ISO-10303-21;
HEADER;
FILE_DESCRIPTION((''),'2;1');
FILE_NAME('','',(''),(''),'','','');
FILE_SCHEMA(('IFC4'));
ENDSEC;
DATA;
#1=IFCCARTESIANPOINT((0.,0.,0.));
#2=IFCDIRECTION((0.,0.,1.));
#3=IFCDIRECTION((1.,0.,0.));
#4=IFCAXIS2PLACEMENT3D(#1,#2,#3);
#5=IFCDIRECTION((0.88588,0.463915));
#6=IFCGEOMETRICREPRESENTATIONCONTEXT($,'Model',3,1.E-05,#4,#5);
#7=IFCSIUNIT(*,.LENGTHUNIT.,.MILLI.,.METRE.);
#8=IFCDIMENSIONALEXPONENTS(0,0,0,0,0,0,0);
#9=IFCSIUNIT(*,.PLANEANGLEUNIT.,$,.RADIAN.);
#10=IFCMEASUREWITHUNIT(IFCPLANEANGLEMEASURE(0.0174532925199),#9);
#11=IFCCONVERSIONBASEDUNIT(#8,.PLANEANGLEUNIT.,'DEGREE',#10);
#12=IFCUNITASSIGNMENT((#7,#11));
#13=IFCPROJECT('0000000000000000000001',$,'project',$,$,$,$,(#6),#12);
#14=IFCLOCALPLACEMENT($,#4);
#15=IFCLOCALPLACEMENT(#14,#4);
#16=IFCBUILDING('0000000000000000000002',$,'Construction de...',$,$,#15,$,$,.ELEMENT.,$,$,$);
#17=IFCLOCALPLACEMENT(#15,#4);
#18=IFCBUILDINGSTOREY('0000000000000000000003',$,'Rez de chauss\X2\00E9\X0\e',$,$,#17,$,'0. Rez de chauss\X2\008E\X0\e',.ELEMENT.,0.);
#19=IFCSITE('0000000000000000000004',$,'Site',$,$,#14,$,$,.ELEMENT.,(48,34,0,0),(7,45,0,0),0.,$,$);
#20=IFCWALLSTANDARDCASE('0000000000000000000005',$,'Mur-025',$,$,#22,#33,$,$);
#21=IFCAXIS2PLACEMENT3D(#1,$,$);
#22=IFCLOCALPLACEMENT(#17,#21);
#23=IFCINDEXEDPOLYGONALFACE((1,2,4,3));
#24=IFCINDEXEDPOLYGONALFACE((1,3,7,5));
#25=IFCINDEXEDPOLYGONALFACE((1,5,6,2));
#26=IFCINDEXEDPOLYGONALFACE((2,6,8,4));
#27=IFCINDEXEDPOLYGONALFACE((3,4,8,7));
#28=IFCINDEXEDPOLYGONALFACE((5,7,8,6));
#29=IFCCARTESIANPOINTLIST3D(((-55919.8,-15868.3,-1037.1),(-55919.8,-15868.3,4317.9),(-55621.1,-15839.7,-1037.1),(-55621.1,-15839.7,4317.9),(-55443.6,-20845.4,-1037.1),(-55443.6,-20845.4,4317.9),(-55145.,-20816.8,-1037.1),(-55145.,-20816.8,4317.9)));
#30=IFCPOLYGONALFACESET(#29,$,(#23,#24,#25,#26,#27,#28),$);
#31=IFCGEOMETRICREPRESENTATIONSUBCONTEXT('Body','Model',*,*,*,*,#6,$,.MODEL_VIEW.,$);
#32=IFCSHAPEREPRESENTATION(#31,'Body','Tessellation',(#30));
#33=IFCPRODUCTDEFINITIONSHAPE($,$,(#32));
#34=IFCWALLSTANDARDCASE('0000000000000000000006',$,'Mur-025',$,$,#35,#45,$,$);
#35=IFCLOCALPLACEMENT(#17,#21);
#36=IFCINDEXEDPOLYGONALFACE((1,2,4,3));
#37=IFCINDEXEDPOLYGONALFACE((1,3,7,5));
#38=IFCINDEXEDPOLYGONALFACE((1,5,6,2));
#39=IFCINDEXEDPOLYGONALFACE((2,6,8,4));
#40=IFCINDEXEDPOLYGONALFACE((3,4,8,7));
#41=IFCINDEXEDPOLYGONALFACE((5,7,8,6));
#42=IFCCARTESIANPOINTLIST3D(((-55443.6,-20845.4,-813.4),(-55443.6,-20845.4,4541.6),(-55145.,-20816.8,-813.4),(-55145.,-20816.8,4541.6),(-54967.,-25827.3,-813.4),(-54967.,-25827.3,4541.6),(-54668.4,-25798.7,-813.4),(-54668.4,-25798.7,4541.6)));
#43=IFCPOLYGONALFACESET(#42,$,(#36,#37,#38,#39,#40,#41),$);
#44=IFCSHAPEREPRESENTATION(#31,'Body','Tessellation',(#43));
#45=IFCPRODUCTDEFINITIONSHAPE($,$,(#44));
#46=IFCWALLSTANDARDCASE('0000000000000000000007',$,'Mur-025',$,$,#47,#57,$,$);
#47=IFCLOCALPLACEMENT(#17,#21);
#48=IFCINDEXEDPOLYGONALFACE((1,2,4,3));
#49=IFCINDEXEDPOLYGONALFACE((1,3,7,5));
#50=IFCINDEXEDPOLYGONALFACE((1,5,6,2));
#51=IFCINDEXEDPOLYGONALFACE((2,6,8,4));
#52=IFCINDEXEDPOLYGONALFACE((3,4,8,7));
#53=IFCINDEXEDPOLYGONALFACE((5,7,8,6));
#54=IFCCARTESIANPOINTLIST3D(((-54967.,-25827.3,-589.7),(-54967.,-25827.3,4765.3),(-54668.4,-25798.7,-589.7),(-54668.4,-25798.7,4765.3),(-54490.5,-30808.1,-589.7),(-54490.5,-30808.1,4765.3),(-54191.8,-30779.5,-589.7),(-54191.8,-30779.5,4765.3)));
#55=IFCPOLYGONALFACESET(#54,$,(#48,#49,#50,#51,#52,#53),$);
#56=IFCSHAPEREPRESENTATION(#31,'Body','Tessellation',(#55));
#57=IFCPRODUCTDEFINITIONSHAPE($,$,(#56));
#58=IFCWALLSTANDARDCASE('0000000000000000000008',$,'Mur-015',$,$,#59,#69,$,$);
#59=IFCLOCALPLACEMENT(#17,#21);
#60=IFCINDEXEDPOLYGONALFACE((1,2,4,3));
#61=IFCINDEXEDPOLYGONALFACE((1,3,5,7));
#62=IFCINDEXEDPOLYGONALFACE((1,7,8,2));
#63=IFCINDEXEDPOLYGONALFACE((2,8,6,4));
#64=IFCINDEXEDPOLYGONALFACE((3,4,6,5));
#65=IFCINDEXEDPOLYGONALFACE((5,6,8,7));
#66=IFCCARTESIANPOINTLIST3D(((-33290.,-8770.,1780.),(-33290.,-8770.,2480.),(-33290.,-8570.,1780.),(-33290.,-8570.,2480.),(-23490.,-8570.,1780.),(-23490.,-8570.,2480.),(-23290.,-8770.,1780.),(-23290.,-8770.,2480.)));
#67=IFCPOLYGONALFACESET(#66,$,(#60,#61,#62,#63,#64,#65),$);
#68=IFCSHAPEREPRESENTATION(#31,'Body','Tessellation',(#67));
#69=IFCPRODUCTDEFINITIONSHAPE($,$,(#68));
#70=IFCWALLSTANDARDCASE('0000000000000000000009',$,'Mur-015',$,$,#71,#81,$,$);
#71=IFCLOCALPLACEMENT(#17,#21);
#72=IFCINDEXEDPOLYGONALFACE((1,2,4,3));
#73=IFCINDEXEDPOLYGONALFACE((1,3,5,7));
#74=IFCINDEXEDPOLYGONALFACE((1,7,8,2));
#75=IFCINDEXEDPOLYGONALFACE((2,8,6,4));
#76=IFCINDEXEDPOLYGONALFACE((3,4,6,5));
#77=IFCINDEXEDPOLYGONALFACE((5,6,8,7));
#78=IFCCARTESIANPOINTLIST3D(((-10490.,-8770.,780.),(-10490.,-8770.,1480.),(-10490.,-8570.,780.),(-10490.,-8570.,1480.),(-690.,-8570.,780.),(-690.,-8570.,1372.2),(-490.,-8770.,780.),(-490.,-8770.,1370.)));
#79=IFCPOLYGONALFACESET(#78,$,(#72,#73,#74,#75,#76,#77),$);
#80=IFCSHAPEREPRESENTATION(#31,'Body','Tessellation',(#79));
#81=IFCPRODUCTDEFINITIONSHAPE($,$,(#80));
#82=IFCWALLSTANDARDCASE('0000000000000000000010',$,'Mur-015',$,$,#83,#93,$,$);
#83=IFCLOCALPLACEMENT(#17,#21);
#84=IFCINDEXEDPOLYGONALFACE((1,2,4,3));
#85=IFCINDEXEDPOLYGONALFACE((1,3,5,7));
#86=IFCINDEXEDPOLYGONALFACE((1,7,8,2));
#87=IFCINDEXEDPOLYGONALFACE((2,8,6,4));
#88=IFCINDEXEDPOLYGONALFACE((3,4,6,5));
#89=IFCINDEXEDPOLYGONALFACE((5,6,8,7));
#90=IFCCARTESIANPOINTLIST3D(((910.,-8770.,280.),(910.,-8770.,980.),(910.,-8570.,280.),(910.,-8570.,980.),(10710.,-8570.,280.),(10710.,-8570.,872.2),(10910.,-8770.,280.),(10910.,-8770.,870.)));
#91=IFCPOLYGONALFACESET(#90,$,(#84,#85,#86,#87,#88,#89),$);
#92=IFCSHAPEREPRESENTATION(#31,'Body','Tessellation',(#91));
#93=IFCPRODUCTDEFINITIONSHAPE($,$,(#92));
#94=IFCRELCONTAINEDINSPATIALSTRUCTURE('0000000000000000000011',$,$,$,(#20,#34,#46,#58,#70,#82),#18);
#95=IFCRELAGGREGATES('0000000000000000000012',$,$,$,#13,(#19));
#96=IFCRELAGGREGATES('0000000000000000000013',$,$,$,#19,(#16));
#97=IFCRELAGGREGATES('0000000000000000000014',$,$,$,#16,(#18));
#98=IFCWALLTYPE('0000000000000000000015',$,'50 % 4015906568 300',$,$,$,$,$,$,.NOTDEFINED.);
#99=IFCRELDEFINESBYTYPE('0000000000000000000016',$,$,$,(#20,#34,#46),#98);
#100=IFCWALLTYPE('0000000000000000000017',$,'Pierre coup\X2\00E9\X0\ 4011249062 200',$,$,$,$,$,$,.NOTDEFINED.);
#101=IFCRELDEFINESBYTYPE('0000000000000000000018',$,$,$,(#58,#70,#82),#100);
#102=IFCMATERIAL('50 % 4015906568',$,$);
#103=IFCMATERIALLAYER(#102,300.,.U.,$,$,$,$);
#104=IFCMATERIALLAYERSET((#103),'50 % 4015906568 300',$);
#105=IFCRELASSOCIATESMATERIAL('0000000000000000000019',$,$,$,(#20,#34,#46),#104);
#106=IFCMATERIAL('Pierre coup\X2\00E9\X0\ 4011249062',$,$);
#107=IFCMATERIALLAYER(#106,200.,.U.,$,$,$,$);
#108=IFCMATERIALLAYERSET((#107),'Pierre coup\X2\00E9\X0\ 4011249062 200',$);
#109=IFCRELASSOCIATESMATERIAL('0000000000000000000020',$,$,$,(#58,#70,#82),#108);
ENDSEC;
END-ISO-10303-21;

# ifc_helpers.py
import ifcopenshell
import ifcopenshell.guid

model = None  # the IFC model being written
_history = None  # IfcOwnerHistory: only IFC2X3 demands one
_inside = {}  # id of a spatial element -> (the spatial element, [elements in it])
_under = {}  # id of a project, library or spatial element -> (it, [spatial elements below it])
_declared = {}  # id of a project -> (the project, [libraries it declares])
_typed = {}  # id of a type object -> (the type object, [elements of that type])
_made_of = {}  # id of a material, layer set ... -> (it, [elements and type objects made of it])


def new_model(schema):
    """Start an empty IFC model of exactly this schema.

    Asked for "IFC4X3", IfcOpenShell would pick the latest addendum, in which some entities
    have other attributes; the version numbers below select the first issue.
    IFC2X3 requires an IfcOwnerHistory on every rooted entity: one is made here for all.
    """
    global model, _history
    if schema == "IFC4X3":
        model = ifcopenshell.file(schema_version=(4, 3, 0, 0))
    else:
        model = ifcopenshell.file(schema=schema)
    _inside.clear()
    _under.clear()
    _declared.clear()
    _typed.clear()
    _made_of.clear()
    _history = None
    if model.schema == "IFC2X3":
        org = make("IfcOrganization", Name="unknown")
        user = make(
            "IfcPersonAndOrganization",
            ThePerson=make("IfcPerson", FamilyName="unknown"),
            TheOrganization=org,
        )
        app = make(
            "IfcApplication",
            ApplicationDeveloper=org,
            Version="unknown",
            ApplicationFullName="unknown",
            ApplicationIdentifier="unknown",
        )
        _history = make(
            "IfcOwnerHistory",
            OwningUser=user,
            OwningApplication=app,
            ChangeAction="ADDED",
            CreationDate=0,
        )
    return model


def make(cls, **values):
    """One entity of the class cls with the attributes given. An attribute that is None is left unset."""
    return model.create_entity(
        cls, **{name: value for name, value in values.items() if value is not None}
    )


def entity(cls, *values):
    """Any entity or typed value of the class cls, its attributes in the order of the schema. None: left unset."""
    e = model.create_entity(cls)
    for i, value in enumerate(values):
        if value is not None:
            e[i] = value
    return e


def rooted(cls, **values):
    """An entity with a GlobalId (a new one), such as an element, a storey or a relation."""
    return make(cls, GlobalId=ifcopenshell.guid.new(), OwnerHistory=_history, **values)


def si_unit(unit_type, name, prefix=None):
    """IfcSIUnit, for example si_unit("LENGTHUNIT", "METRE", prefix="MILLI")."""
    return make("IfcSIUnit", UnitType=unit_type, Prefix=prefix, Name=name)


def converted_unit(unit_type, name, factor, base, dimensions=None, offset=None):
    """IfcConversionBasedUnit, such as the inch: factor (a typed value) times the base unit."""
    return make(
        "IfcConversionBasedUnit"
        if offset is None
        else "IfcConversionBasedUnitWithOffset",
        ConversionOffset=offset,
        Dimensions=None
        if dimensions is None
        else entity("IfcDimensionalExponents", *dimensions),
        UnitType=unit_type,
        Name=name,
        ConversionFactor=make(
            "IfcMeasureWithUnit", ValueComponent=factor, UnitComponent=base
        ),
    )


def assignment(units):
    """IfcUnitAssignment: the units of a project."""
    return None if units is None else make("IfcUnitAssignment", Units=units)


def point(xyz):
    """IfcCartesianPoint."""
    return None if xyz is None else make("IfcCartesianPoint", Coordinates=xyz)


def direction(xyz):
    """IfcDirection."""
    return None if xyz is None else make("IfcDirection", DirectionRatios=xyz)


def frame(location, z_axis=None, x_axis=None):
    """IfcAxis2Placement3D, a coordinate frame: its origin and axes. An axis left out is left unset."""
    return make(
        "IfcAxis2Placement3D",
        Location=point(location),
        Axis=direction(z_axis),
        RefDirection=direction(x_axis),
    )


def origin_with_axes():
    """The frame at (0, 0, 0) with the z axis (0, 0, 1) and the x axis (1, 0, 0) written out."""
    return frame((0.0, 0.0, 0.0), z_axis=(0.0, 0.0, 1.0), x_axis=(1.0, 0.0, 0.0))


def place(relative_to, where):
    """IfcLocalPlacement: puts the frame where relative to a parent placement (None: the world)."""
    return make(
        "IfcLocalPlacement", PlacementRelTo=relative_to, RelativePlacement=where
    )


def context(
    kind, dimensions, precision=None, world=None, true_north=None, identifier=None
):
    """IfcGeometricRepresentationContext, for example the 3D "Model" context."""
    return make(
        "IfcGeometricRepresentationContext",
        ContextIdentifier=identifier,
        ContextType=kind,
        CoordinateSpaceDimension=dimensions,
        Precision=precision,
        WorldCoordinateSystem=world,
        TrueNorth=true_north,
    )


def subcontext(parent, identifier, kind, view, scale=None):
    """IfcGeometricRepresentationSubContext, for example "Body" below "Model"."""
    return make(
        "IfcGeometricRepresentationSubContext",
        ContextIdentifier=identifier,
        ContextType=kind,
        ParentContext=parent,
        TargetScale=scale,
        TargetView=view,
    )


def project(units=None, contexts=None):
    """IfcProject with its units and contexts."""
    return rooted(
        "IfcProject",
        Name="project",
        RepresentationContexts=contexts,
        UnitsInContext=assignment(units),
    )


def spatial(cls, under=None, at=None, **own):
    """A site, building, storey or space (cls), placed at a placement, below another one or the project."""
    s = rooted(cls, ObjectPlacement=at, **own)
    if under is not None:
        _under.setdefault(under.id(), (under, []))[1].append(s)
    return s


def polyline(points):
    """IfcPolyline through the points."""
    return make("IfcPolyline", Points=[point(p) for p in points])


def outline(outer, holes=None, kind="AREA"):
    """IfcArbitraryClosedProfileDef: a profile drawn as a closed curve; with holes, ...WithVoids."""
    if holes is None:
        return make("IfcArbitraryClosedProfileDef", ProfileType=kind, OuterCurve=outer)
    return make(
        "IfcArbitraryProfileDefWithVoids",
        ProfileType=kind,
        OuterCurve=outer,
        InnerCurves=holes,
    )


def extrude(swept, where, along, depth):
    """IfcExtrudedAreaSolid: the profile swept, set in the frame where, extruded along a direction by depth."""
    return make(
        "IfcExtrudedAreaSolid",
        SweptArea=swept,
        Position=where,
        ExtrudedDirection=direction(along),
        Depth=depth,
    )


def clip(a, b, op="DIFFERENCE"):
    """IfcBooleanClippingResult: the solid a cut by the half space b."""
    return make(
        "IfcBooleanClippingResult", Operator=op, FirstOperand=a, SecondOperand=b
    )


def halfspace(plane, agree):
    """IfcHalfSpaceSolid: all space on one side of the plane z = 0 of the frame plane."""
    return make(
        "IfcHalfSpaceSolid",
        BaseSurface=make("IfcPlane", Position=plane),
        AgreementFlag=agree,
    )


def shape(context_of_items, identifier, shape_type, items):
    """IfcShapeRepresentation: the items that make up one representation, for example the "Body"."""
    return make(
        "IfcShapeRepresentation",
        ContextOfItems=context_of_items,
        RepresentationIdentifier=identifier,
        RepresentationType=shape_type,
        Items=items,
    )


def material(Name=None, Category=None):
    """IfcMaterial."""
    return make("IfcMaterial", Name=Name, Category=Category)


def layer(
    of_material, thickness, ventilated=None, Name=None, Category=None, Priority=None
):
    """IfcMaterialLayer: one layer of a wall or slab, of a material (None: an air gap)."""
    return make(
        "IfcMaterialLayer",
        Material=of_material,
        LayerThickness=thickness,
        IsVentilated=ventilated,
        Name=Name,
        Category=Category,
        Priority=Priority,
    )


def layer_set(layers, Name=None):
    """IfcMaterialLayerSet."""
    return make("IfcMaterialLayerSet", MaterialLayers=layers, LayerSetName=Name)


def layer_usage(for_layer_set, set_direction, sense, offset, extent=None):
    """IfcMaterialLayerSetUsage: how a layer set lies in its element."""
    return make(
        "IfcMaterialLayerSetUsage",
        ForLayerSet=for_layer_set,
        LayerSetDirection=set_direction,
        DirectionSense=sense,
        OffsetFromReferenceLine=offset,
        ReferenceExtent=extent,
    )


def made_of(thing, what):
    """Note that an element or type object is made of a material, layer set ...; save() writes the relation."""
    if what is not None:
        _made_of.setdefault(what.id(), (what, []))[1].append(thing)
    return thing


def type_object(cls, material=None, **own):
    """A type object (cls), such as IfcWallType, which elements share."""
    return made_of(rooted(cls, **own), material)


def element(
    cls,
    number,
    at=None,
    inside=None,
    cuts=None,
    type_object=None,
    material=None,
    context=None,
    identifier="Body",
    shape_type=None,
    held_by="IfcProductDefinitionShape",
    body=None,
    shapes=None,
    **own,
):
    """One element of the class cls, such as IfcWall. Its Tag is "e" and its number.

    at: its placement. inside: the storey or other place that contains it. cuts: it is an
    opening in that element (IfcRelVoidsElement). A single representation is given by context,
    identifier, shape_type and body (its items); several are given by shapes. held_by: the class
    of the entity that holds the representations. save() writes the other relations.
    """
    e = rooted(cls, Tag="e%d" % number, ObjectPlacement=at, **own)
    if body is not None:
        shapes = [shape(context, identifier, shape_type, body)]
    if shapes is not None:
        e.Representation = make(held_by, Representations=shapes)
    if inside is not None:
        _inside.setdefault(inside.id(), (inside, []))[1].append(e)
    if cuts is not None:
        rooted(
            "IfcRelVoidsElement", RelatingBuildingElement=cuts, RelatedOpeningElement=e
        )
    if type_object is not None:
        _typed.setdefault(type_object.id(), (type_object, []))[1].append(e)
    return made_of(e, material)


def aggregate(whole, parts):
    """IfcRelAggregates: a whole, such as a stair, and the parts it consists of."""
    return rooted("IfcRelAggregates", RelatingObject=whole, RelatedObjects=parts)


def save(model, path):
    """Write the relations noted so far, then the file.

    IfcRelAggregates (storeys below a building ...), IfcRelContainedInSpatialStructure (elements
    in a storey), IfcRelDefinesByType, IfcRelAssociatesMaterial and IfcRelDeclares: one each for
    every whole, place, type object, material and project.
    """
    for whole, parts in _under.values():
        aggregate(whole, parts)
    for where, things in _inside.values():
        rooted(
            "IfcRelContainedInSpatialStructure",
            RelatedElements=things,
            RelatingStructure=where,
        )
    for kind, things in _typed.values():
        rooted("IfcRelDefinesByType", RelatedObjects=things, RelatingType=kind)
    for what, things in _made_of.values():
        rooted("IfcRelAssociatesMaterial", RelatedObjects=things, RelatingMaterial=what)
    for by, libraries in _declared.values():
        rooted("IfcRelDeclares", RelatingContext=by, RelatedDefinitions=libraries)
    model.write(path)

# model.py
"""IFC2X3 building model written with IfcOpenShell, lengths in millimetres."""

from ifc_helpers import new_model, entity, si_unit, converted_unit, direction, frame, origin_with_axes, place, context, subcontext, project, spatial, polyline, outline, extrude, clip, halfspace, material, layer, layer_set, layer_usage, type_object, element, save


model = new_model("IFC2X3")

# Units and contexts
model_context = context("Model", 3, precision=1e-05, world=origin_with_axes(), true_north=direction((0.88588, 0.463915)))
body_context = subcontext(model_context, "Body", "Model", "MODEL_VIEW")
ifc_project = project(units=[si_unit("LENGTHUNIT", "METRE", prefix="MILLI"), converted_unit("PLANEANGLEUNIT", "DEGREE", entity("IfcPlaneAngleMeasure", 0.0174532925199), si_unit("PLANEANGLEUNIT", "RADIAN"), dimensions=[0, 0, 0, 0, 0, 0, 0])], contexts=[model_context])

# Site, building, storey
site_placement = place(None, origin_with_axes())
site = spatial("IfcSite", under=ifc_project, at=site_placement, Name="Site", CompositionType="ELEMENT", RefLatitude=(48, 34, 0, 0), RefLongitude=(7, 45, 0, 0), RefElevation=0.0)
building_placement = place(site_placement, origin_with_axes())
building = spatial("IfcBuilding", under=site, at=building_placement, Name="Construction de...", CompositionType="ELEMENT")
storey_placement = place(building_placement, origin_with_axes())
storey = spatial("IfcBuildingStorey", under=building, at=storey_placement, Name="Rez de chaussée", LongName="0. Rez de chauss\u008ee", CompositionType="ELEMENT", Elevation=0.0)

# Walls
ifc_material_1 = material(Name="50 % 4015906568")
ifc_layer_1 = layer(ifc_material_1, 300.0, ventilated="UNKNOWN")
ifc_layer_set_1 = layer_set([ifc_layer_1], Name="50 % 4015906568 300")
wall_type_1 = type_object("IfcWallType", Name="50 % 4015906568 300", PredefinedType="NOTDEFINED")
ifc_layer_usage_1 = layer_usage(ifc_layer_set_1, "AXIS2", "NEGATIVE", 150.0)
wall_1_placement = place(storey_placement, frame((-55770.5, -15854.0, -1037.1), z_axis=(0.0, 0.0, 1.0), x_axis=(0.095235, -0.995455, 0.0)))
element("IfcWallStandardCase", 1, at=wall_1_placement, inside=storey, type_object=wall_type_1, material=ifc_layer_usage_1, Name="Mur-025", context=body_context, shape_type="SweptSolid", body=[
    extrude(outline(polyline([(0.0, -150.0), (4999.8, -150.0), (4999.8, 150.0), (0.0, 150.0), (0.0, -150.0)])), origin_with_axes(), (0.0, 0.0, 1.0), 5355.0),
])
ifc_layer_usage_2 = layer_usage(ifc_layer_set_1, "AXIS2", "NEGATIVE", 150.0)
wall_2_placement = place(storey_placement, frame((-55294.3, -20831.1, -813.4), z_axis=(0.0, 0.0, 1.0), x_axis=(0.095235, -0.995455, 0.0)))
element("IfcWallStandardCase", 2, at=wall_2_placement, inside=storey, type_object=wall_type_1, material=ifc_layer_usage_2, Name="Mur-025", context=body_context, shape_type="SweptSolid", body=[
    extrude(outline(polyline([(0.0, -150.0), (5004.6, -150.0), (5004.6, 150.0), (0.0, 150.0), (0.0, -150.0)])), origin_with_axes(), (0.0, 0.0, 1.0), 5355.0),
])
ifc_layer_usage_3 = layer_usage(ifc_layer_set_1, "AXIS2", "NEGATIVE", 150.0)
wall_3_placement = place(storey_placement, frame((-54817.7, -25813.0, -589.7), z_axis=(0.0, 0.0, 1.0), x_axis=(0.095235, -0.995455, 0.0)))
element("IfcWallStandardCase", 3, at=wall_3_placement, inside=storey, type_object=wall_type_1, material=ifc_layer_usage_3, Name="Mur-025", context=body_context, shape_type="SweptSolid", body=[
    extrude(outline(polyline([(0.0, -150.0), (5003.5, -150.0), (5003.5, 150.0), (0.0, 150.0), (0.0, -150.0)])), origin_with_axes(), (0.0, 0.0, 1.0), 5355.0),
])
ifc_material_2 = material(Name="Pierre coupé 4011249062")
ifc_layer_2 = layer(ifc_material_2, 200.0, ventilated="UNKNOWN")
ifc_layer_set_2 = layer_set([ifc_layer_2], Name="Pierre coupé 4011249062 200")
ifc_layer_usage_4 = layer_usage(ifc_layer_set_2, "AXIS2", "NEGATIVE", 100.0)
wall_type_2 = type_object("IfcWallType", Name="Pierre coupé 4011249062 200", PredefinedType="NOTDEFINED")
wall_4_placement = place(storey_placement, frame((-33290.0, -8670.0, 1780.0), z_axis=(0.0, 0.0, 1.0), x_axis=(1.0, 0.0, 0.0)))
element("IfcWallStandardCase", 4, at=wall_4_placement, inside=storey, type_object=wall_type_2, material=ifc_layer_usage_4, Name="Mur-015", context=body_context, shape_type="SweptSolid", body=[
    extrude(outline(polyline([(0.0, -100.0), (10000.0, -100.0), (9800.0, 100.0), (0.0, 100.0), (0.0, -100.0)])), origin_with_axes(), (0.0, 0.0, 1.0), 700.0),
])
ifc_layer_usage_5 = layer_usage(ifc_layer_set_2, "AXIS2", "NEGATIVE", 100.0)
wall_5_placement = place(storey_placement, frame((-10490.0, -8670.0, 780.0), z_axis=(0.0, 0.0, 1.0), x_axis=(1.0, 0.0, 0.0)))
element("IfcWallStandardCase", 5, at=wall_5_placement, inside=storey, type_object=wall_type_2, material=ifc_layer_usage_5, Name="Mur-015", context=body_context, shape_type="Clipping", body=[
    clip(extrude(outline(polyline([(0.0, -100.0), (10000.0, -100.0), (9800.0, 100.0), (0.0, 100.0), (0.0, -100.0)])), origin_with_axes(), (0.0, 0.0, 1.0), 700.0), halfspace(frame((7.7, 0.0, 699.9), z_axis=(-0.010999, 0.0, -0.99994), x_axis=(0.0, 1.0, 0.0)), True)),
])
ifc_layer_usage_6 = layer_usage(ifc_layer_set_2, "AXIS2", "NEGATIVE", 100.0)
wall_6_placement = place(storey_placement, frame((910.0, -8670.0, 280.0), z_axis=(0.0, 0.0, 1.0), x_axis=(1.0, 0.0, 0.0)))
element("IfcWallStandardCase", 6, at=wall_6_placement, inside=storey, type_object=wall_type_2, material=ifc_layer_usage_6, Name="Mur-015", context=body_context, shape_type="Clipping", body=[
    clip(extrude(outline(polyline([(0.0, -100.0), (10000.0, -100.0), (9800.0, 100.0), (0.0, 100.0), (0.0, -100.0)])), origin_with_axes(), (0.0, 0.0, 1.0), 700.0), halfspace(frame((7.7, 0.0, 699.9), z_axis=(-0.010999, 0.0, -0.99994), x_axis=(0.0, 1.0, 0.0)), True)),
])

save(model, "model.ifc")
